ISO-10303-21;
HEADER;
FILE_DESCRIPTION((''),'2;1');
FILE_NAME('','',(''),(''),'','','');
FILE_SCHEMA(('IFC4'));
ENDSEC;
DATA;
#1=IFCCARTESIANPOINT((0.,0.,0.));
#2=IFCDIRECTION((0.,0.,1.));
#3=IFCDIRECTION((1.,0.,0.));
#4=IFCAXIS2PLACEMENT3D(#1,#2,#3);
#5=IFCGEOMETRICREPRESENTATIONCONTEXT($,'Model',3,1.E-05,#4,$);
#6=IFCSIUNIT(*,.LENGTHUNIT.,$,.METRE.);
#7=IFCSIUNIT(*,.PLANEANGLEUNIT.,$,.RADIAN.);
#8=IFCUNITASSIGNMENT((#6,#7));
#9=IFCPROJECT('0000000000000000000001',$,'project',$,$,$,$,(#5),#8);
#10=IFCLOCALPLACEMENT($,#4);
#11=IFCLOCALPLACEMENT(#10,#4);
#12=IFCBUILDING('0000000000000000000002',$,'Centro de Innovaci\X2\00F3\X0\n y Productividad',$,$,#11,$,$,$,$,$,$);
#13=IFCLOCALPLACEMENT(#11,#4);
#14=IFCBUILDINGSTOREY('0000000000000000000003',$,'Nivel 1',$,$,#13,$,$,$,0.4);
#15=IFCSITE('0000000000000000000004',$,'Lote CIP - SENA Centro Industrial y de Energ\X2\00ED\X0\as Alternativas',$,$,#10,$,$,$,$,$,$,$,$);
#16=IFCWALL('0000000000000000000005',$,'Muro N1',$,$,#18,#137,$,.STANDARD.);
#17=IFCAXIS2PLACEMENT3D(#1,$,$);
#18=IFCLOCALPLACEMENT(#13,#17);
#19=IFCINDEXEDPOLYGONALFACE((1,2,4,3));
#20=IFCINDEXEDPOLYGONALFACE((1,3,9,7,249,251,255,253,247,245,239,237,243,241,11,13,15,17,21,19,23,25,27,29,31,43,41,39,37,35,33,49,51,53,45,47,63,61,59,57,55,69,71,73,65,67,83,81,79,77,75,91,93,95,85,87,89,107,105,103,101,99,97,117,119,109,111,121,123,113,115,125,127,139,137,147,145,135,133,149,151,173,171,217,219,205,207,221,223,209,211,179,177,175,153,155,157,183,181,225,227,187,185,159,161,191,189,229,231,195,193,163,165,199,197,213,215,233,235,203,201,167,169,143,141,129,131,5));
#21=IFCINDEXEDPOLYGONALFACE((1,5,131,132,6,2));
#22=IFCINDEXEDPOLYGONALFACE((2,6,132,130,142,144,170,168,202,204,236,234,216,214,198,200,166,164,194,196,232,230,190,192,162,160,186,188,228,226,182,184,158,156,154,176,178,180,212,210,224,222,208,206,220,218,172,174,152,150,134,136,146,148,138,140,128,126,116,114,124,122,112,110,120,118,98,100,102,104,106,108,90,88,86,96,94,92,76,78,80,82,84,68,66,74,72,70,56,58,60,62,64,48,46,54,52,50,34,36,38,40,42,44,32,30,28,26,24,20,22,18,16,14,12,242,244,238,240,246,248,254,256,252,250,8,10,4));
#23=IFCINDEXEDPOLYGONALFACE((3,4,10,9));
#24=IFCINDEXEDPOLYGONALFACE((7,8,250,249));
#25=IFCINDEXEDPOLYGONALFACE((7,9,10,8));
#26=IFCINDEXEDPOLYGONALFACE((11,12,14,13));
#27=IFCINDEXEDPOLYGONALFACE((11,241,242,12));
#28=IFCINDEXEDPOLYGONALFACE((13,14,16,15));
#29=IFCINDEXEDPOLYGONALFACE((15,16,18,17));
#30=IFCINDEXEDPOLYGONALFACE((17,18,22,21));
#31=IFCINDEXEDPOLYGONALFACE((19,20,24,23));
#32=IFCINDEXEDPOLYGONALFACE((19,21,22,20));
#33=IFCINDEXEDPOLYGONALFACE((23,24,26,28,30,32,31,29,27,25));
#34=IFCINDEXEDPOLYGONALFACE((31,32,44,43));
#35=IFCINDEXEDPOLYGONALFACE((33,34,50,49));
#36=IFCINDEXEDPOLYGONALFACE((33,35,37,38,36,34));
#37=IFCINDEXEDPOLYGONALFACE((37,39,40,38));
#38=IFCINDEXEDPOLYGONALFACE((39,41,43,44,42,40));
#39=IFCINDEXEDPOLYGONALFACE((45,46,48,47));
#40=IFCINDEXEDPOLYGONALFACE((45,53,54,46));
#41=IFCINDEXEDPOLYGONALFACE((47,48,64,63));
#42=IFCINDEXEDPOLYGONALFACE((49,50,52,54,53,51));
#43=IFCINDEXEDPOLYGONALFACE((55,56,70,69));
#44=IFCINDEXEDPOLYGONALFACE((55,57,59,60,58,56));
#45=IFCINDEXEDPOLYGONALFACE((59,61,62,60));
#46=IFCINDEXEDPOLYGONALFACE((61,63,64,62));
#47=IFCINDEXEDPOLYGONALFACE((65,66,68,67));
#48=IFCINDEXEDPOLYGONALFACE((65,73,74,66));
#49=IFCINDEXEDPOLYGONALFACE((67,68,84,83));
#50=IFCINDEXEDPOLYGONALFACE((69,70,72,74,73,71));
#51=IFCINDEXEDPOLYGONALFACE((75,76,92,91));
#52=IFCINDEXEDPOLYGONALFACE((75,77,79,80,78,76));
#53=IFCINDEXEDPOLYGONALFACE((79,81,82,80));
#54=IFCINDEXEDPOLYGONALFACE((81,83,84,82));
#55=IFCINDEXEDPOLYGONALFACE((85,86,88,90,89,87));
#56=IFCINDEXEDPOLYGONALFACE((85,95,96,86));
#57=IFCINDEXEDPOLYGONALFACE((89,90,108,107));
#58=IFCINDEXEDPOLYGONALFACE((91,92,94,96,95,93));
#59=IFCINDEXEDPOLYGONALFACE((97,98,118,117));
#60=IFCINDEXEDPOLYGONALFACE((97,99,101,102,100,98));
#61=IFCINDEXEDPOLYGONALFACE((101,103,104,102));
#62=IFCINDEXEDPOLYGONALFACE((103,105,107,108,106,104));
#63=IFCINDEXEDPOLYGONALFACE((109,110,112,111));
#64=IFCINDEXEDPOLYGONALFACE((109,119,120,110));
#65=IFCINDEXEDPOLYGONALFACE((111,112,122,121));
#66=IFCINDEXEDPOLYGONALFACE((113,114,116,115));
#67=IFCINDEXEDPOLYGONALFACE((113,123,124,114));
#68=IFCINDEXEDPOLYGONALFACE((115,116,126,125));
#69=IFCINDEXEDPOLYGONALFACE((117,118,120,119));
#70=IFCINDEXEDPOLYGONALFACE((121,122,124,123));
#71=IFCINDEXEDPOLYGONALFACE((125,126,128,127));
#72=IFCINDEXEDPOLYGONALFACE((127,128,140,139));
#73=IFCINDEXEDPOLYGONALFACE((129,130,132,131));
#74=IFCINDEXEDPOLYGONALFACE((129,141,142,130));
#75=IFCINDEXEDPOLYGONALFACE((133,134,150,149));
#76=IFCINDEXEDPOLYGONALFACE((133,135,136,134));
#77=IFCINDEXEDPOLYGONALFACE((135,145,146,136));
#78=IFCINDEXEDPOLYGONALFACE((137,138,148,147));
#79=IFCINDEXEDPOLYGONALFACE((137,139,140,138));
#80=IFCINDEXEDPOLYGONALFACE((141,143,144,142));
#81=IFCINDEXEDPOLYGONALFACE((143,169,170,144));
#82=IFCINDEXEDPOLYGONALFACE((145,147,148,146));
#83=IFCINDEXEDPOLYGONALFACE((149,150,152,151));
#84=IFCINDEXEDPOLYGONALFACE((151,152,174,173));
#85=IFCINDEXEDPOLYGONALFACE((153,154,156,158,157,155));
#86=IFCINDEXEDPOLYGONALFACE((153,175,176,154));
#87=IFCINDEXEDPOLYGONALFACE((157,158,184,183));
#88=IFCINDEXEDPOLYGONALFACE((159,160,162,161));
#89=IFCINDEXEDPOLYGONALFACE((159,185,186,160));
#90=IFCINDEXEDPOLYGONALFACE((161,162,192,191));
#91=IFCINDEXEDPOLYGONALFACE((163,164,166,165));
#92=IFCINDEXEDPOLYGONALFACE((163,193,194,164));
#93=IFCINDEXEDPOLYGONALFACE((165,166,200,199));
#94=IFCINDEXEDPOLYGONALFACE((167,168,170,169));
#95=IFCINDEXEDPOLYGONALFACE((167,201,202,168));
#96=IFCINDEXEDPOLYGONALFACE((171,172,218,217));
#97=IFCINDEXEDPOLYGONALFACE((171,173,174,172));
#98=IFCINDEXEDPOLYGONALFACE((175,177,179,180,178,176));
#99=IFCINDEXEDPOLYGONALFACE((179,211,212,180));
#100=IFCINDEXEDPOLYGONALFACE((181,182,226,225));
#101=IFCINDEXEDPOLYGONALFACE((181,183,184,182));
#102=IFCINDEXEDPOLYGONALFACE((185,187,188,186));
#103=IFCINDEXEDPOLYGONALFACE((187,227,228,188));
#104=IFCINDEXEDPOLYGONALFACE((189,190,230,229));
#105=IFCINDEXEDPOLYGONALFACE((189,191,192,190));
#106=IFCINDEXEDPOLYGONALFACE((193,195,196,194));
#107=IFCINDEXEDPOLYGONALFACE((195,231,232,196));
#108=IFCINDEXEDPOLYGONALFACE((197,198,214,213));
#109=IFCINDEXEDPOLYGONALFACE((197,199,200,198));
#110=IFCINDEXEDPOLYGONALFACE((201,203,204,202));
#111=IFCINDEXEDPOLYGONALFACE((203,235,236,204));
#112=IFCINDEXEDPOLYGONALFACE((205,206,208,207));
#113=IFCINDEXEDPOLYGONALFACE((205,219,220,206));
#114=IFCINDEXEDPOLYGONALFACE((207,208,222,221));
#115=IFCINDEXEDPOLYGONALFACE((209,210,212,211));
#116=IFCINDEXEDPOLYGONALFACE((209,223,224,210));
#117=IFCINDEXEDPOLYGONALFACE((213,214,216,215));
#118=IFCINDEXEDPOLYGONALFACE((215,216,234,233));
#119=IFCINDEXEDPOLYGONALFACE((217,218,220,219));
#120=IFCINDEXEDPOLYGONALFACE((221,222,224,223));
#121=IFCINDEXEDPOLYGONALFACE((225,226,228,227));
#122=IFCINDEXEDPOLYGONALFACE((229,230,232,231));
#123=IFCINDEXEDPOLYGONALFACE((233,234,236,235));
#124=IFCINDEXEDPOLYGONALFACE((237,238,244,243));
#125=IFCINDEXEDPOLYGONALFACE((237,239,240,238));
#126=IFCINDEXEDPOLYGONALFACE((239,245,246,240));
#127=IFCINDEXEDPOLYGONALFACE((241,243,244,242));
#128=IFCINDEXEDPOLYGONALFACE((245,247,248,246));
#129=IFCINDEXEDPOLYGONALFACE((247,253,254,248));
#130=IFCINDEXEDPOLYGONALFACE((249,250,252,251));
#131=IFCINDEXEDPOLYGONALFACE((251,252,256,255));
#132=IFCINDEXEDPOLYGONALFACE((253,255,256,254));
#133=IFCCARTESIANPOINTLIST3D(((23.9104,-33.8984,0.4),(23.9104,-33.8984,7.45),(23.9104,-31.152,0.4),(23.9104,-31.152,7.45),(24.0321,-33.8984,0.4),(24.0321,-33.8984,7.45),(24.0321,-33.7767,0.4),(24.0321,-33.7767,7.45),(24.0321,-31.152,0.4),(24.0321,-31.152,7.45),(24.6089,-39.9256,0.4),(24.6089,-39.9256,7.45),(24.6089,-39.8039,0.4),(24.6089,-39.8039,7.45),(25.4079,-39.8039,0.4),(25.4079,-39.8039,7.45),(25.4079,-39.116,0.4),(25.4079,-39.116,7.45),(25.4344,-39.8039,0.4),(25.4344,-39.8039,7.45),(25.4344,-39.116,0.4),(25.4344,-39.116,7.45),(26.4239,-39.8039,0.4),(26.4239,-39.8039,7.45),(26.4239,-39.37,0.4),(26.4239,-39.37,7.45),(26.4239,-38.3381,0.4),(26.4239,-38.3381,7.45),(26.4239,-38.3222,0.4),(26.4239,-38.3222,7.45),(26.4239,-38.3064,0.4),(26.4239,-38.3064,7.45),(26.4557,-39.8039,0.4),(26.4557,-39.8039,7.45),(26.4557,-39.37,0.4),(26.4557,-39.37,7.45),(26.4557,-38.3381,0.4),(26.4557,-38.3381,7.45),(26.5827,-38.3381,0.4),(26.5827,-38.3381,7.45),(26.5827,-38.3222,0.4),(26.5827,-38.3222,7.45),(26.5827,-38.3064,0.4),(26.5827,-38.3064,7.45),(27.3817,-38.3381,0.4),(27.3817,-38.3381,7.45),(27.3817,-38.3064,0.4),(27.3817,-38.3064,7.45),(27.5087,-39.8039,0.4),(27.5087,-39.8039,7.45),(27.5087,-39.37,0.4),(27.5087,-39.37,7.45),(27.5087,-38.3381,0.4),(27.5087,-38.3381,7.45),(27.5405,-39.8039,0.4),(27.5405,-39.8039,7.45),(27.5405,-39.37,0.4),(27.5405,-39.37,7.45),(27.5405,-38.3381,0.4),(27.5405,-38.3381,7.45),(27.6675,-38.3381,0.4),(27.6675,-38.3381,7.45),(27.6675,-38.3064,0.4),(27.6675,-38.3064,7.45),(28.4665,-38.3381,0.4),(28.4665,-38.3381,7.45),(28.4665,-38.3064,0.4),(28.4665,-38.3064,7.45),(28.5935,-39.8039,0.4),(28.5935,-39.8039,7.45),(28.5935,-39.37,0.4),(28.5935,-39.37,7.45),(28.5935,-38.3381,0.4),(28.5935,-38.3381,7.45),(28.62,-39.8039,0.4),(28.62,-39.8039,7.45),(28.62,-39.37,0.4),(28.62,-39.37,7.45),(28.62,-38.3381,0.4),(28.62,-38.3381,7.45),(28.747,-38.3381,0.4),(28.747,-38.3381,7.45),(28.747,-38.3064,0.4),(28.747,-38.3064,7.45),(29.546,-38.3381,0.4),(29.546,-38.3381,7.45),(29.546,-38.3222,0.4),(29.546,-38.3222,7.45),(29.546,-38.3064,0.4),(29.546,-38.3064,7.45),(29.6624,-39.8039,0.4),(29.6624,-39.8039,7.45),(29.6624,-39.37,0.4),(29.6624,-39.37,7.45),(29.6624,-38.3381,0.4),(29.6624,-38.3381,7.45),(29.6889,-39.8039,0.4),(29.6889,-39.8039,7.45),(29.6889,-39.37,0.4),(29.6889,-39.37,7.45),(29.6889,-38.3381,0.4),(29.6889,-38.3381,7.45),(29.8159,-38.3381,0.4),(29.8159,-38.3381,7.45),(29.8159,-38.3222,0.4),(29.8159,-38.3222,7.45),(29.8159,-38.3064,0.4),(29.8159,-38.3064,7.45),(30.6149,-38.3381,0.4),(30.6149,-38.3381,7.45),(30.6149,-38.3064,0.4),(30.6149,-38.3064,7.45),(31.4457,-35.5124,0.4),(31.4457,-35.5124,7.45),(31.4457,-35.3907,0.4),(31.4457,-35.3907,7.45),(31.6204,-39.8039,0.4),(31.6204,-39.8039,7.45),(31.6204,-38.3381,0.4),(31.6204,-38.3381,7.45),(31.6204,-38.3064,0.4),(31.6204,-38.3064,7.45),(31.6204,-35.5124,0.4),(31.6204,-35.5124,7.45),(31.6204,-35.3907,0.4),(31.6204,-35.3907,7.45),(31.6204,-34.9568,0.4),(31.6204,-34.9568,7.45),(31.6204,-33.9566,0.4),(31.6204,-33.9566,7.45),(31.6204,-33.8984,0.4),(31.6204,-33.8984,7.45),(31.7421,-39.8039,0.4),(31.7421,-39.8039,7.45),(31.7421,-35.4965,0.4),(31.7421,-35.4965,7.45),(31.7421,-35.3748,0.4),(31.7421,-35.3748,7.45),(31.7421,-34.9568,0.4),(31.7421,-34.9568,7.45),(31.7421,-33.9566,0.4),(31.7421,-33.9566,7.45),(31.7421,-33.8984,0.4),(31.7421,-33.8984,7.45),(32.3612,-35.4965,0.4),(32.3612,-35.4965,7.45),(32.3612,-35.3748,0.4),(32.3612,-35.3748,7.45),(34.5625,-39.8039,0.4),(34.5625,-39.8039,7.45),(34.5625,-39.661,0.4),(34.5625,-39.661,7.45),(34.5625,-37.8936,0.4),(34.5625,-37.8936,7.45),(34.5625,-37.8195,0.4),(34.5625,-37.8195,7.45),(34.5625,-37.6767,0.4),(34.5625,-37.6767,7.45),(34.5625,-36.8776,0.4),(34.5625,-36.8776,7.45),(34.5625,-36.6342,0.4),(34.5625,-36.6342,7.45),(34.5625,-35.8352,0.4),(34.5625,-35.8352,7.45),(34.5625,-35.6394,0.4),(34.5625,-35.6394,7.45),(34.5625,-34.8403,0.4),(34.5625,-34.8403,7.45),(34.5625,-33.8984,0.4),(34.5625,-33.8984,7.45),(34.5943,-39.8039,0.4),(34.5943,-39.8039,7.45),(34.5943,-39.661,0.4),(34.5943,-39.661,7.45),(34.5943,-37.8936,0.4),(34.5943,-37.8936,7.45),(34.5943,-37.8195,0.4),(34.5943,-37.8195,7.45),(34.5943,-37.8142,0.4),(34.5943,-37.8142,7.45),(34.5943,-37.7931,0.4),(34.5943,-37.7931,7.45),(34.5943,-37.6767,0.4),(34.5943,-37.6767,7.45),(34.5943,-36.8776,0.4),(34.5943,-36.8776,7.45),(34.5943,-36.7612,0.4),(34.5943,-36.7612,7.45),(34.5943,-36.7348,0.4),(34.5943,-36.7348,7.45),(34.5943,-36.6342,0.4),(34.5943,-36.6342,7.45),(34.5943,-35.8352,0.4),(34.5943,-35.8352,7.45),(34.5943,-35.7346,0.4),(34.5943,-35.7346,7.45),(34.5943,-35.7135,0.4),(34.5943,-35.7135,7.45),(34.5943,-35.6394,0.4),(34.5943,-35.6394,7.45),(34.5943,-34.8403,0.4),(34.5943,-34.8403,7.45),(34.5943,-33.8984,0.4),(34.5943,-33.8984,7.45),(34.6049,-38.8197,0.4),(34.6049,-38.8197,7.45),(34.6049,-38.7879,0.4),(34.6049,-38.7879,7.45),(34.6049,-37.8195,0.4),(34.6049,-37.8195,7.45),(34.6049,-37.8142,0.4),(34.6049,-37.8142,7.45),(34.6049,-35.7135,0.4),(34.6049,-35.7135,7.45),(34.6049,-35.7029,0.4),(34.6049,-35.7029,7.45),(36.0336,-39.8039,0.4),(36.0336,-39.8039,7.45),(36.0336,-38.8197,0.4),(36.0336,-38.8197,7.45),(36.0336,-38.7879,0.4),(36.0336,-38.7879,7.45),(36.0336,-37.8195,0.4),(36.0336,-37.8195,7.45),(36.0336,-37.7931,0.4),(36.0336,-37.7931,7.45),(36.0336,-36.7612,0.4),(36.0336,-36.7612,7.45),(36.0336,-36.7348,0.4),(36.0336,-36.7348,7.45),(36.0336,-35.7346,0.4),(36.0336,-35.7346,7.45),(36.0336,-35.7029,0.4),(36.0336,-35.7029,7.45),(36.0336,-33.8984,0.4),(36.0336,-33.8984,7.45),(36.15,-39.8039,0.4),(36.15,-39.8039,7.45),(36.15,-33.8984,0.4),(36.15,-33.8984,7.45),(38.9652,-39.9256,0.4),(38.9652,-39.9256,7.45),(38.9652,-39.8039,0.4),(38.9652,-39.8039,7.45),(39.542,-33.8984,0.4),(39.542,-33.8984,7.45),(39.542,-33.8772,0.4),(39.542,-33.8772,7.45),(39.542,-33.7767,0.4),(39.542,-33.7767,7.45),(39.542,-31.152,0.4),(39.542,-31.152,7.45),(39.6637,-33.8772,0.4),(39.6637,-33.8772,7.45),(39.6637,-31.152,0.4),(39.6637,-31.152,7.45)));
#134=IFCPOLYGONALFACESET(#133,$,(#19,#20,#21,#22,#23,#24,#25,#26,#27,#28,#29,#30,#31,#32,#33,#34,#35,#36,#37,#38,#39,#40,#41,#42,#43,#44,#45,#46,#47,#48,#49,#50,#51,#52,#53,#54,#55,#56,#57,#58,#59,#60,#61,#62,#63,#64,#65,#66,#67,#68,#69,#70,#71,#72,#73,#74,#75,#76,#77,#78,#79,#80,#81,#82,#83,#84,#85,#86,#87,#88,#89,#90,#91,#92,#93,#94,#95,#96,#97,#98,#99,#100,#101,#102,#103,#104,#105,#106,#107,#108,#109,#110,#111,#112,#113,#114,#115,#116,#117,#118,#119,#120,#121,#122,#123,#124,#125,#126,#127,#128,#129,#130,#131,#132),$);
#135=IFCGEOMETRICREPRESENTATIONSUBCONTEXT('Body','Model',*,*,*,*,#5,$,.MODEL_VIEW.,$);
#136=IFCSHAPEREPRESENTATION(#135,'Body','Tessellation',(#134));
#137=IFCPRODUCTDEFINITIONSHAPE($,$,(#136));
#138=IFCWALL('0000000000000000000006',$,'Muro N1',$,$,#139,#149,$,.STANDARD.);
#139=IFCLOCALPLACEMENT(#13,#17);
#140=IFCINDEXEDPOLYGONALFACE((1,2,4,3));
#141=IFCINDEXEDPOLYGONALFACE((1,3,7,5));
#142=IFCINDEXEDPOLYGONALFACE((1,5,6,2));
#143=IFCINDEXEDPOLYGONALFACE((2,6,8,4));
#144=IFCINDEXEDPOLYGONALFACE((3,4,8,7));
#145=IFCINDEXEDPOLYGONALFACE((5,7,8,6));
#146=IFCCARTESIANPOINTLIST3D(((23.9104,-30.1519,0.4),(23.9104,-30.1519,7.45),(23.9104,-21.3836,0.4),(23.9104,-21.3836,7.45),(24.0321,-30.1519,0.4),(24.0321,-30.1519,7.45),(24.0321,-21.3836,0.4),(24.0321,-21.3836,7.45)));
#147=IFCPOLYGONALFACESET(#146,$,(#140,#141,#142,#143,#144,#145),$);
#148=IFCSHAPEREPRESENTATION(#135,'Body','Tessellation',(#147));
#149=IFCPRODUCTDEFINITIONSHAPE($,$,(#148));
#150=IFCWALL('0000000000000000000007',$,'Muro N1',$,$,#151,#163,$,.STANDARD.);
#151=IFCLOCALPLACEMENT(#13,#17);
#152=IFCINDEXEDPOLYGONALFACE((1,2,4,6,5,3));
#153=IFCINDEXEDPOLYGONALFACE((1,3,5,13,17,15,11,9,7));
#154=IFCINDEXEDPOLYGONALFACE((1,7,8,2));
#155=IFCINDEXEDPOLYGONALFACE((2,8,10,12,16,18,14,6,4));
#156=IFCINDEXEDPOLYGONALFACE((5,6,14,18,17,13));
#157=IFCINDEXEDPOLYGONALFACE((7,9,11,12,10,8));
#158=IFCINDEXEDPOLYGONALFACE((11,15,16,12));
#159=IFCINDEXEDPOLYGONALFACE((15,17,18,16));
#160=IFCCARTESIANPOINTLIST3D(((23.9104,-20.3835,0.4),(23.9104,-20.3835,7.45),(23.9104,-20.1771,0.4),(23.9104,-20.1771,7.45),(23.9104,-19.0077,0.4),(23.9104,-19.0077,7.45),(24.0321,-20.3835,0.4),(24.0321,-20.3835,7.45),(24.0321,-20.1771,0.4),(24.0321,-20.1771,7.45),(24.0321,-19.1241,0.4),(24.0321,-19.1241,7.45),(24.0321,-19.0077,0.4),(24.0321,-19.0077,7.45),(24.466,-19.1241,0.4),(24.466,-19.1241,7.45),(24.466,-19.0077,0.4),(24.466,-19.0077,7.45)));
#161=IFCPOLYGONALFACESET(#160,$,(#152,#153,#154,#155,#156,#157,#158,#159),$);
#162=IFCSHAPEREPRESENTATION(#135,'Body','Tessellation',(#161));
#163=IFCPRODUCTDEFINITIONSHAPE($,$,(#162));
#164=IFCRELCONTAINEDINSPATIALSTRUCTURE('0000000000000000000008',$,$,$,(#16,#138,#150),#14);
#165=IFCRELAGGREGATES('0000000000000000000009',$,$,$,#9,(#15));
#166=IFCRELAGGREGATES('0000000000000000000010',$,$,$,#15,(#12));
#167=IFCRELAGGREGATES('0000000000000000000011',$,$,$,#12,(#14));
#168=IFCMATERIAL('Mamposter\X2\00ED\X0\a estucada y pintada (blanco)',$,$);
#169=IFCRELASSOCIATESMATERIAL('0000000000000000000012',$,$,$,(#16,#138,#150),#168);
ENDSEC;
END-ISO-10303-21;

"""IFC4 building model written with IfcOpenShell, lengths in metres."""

from ifc_helpers import new_model, si_unit, frame, origin_with_axes, place, context, subcontext, project, spatial, polyline, outline, extrude, material, element, save


model = new_model("IFC4")

# Units and contexts
model_context = context("Model", 3, precision=1e-05, world=origin_with_axes())
body_context = subcontext(model_context, "Body", "Model", "MODEL_VIEW")
ifc_project = project(units=[si_unit("LENGTHUNIT", "METRE"), si_unit("PLANEANGLEUNIT", "RADIAN")], contexts=[model_context])

# Site, building, storey
site_placement = place(None, origin_with_axes())
site = spatial("IfcSite", under=ifc_project, at=site_placement, Name="Lote CIP - SENA Centro Industrial y de Energías Alternativas")
building_placement = place(site_placement, origin_with_axes())
building = spatial("IfcBuilding", under=site, at=building_placement, Name="Centro de Innovación y Productividad")
storey_placement = place(building_placement, origin_with_axes())
storey = spatial("IfcBuildingStorey", under=building, at=storey_placement, Name="Nivel 1", Elevation=0.4)

# Walls
ifc_material = material(Name="Mampostería estucada y pintada (blanco)")
wall_1_placement = place(storey_placement, origin_with_axes())
element("IfcWall", 1, at=wall_1_placement, inside=storey, material=ifc_material, Name="Muro N1", PredefinedType="STANDARD", context=body_context, shape_type="SweptSolid", body=[
    extrude(outline(polyline([(23.9104, -33.8984), (23.9104, -31.152), (24.0321, -31.152), (24.0321, -33.7767), (39.542, -33.7767), (39.542, -31.152), (39.6637, -31.152), (39.6637, -33.8772), (39.542, -33.8772), (39.542, -33.8984), (36.15, -33.8984), (36.15, -39.8039), (38.9652, -39.8039), (38.9652, -39.9256), (24.6089, -39.9256), (24.6089, -39.8039), (25.4079, -39.8039), (25.4079, -39.116), (25.4344, -39.116), (25.4344, -39.8039), (26.4239, -39.8039), (26.4239, -39.37), (26.4239, -38.3381), (26.4239, -38.3222), (26.4239, -38.3064), (26.5827, -38.3064), (26.5827, -38.3222), (26.5827, -38.3381), (26.4557, -38.3381), (26.4557, -39.37), (26.4557, -39.8039), (27.5087, -39.8039), (27.5087, -39.37), (27.5087, -38.3381), (27.3817, -38.3381), (27.3817, -38.3064), (27.6675, -38.3064), (27.6675, -38.3381), (27.5405, -38.3381), (27.5405, -39.37), (27.5405, -39.8039), (28.5935, -39.8039), (28.5935, -39.37), (28.5935, -38.3381), (28.4665, -38.3381), (28.4665, -38.3064), (28.747, -38.3064), (28.747, -38.3381), (28.62, -38.3381), (28.62, -39.37), (28.62, -39.8039), (29.6624, -39.8039), (29.6624, -39.37), (29.6624, -38.3381), (29.546, -38.3381), (29.546, -38.3222), (29.546, -38.3064), (29.8159, -38.3064), (29.8159, -38.3222), (29.8159, -38.3381), (29.6889, -38.3381), (29.6889, -39.37), (29.6889, -39.8039), (31.6204, -39.8039), (31.6204, -38.3381), (30.6149, -38.3381), (30.6149, -38.3064), (31.6204, -38.3064), (31.6204, -35.5124), (31.4457, -35.5124), (31.4457, -35.3907), (31.6204, -35.3907), (31.6204, -34.9567), (31.7421, -34.9567), (31.7421, -35.3748), (32.3612, -35.3748), (32.3612, -35.4965), (31.7421, -35.4965), (31.7421, -39.8039), (34.5625, -39.8039), (34.5625, -39.661), (34.5943, -39.661), (34.5943, -39.8039), (36.0336, -39.8039), (36.0336, -38.8197), (34.6049, -38.8197), (34.6049, -38.7879), (36.0336, -38.7879), (36.0336, -37.8195), (34.6049, -37.8195), (34.6049, -37.8142), (34.5943, -37.8142), (34.5943, -37.8195), (34.5943, -37.8936), (34.5625, -37.8936), (34.5625, -37.8195), (34.5625, -37.6767), (34.5943, -37.6767), (34.5943, -37.7931), (36.0336, -37.7931), (36.0336, -36.7612), (34.5943, -36.7612), (34.5943, -36.8776), (34.5625, -36.8776), (34.5625, -36.6342), (34.5943, -36.6342), (34.5943, -36.7347), (36.0336, -36.7347), (36.0336, -35.7346), (34.5943, -35.7346), (34.5943, -35.8352), (34.5625, -35.8352), (34.5625, -35.6394), (34.5943, -35.6394), (34.5943, -35.7135), (34.6049, -35.7135), (34.6049, -35.7029), (36.0336, -35.7029), (36.0336, -33.8984), (34.5943, -33.8984), (34.5943, -34.8403), (34.5625, -34.8403), (34.5625, -33.8984), (31.7421, -33.8984), (31.7421, -33.9566), (31.6204, -33.9566), (31.6204, -33.8984), (24.0321, -33.8984), (23.9104, -33.8984)])), frame((0.0, 0.0, 0.4)), (0.0, 0.0, 1.0), 7.05),
])
wall_2_placement = place(storey_placement, origin_with_axes())
element("IfcWall", 2, at=wall_2_placement, inside=storey, material=ifc_material, Name="Muro N1", PredefinedType="STANDARD", context=body_context, shape_type="SweptSolid", body=[
    extrude(outline(polyline([(23.9104, -21.3836), (24.0321, -21.3836), (24.0321, -30.1519), (23.9104, -30.1519), (23.9104, -21.3836)])), frame((0.0, 0.0, 0.4)), (0.0, 0.0, 1.0), 7.05),
])
wall_3_placement = place(storey_placement, origin_with_axes())
element("IfcWall", 3, at=wall_3_placement, inside=storey, material=ifc_material, Name="Muro N1", PredefinedType="STANDARD", context=body_context, shape_type="SweptSolid", body=[
    extrude(outline(polyline([(23.9104, -20.3835), (23.9104, -20.1771), (23.9104, -19.0077), (24.0321, -19.0077), (24.466, -19.0077), (24.466, -19.1241), (24.0321, -19.1241), (24.0321, -20.1771), (24.0321, -20.3835), (23.9104, -20.3835)])), frame((0.0, 0.0, 0.4)), (0.0, 0.0, 1.0), 7.05),
])

save(model, "model.ifc")
